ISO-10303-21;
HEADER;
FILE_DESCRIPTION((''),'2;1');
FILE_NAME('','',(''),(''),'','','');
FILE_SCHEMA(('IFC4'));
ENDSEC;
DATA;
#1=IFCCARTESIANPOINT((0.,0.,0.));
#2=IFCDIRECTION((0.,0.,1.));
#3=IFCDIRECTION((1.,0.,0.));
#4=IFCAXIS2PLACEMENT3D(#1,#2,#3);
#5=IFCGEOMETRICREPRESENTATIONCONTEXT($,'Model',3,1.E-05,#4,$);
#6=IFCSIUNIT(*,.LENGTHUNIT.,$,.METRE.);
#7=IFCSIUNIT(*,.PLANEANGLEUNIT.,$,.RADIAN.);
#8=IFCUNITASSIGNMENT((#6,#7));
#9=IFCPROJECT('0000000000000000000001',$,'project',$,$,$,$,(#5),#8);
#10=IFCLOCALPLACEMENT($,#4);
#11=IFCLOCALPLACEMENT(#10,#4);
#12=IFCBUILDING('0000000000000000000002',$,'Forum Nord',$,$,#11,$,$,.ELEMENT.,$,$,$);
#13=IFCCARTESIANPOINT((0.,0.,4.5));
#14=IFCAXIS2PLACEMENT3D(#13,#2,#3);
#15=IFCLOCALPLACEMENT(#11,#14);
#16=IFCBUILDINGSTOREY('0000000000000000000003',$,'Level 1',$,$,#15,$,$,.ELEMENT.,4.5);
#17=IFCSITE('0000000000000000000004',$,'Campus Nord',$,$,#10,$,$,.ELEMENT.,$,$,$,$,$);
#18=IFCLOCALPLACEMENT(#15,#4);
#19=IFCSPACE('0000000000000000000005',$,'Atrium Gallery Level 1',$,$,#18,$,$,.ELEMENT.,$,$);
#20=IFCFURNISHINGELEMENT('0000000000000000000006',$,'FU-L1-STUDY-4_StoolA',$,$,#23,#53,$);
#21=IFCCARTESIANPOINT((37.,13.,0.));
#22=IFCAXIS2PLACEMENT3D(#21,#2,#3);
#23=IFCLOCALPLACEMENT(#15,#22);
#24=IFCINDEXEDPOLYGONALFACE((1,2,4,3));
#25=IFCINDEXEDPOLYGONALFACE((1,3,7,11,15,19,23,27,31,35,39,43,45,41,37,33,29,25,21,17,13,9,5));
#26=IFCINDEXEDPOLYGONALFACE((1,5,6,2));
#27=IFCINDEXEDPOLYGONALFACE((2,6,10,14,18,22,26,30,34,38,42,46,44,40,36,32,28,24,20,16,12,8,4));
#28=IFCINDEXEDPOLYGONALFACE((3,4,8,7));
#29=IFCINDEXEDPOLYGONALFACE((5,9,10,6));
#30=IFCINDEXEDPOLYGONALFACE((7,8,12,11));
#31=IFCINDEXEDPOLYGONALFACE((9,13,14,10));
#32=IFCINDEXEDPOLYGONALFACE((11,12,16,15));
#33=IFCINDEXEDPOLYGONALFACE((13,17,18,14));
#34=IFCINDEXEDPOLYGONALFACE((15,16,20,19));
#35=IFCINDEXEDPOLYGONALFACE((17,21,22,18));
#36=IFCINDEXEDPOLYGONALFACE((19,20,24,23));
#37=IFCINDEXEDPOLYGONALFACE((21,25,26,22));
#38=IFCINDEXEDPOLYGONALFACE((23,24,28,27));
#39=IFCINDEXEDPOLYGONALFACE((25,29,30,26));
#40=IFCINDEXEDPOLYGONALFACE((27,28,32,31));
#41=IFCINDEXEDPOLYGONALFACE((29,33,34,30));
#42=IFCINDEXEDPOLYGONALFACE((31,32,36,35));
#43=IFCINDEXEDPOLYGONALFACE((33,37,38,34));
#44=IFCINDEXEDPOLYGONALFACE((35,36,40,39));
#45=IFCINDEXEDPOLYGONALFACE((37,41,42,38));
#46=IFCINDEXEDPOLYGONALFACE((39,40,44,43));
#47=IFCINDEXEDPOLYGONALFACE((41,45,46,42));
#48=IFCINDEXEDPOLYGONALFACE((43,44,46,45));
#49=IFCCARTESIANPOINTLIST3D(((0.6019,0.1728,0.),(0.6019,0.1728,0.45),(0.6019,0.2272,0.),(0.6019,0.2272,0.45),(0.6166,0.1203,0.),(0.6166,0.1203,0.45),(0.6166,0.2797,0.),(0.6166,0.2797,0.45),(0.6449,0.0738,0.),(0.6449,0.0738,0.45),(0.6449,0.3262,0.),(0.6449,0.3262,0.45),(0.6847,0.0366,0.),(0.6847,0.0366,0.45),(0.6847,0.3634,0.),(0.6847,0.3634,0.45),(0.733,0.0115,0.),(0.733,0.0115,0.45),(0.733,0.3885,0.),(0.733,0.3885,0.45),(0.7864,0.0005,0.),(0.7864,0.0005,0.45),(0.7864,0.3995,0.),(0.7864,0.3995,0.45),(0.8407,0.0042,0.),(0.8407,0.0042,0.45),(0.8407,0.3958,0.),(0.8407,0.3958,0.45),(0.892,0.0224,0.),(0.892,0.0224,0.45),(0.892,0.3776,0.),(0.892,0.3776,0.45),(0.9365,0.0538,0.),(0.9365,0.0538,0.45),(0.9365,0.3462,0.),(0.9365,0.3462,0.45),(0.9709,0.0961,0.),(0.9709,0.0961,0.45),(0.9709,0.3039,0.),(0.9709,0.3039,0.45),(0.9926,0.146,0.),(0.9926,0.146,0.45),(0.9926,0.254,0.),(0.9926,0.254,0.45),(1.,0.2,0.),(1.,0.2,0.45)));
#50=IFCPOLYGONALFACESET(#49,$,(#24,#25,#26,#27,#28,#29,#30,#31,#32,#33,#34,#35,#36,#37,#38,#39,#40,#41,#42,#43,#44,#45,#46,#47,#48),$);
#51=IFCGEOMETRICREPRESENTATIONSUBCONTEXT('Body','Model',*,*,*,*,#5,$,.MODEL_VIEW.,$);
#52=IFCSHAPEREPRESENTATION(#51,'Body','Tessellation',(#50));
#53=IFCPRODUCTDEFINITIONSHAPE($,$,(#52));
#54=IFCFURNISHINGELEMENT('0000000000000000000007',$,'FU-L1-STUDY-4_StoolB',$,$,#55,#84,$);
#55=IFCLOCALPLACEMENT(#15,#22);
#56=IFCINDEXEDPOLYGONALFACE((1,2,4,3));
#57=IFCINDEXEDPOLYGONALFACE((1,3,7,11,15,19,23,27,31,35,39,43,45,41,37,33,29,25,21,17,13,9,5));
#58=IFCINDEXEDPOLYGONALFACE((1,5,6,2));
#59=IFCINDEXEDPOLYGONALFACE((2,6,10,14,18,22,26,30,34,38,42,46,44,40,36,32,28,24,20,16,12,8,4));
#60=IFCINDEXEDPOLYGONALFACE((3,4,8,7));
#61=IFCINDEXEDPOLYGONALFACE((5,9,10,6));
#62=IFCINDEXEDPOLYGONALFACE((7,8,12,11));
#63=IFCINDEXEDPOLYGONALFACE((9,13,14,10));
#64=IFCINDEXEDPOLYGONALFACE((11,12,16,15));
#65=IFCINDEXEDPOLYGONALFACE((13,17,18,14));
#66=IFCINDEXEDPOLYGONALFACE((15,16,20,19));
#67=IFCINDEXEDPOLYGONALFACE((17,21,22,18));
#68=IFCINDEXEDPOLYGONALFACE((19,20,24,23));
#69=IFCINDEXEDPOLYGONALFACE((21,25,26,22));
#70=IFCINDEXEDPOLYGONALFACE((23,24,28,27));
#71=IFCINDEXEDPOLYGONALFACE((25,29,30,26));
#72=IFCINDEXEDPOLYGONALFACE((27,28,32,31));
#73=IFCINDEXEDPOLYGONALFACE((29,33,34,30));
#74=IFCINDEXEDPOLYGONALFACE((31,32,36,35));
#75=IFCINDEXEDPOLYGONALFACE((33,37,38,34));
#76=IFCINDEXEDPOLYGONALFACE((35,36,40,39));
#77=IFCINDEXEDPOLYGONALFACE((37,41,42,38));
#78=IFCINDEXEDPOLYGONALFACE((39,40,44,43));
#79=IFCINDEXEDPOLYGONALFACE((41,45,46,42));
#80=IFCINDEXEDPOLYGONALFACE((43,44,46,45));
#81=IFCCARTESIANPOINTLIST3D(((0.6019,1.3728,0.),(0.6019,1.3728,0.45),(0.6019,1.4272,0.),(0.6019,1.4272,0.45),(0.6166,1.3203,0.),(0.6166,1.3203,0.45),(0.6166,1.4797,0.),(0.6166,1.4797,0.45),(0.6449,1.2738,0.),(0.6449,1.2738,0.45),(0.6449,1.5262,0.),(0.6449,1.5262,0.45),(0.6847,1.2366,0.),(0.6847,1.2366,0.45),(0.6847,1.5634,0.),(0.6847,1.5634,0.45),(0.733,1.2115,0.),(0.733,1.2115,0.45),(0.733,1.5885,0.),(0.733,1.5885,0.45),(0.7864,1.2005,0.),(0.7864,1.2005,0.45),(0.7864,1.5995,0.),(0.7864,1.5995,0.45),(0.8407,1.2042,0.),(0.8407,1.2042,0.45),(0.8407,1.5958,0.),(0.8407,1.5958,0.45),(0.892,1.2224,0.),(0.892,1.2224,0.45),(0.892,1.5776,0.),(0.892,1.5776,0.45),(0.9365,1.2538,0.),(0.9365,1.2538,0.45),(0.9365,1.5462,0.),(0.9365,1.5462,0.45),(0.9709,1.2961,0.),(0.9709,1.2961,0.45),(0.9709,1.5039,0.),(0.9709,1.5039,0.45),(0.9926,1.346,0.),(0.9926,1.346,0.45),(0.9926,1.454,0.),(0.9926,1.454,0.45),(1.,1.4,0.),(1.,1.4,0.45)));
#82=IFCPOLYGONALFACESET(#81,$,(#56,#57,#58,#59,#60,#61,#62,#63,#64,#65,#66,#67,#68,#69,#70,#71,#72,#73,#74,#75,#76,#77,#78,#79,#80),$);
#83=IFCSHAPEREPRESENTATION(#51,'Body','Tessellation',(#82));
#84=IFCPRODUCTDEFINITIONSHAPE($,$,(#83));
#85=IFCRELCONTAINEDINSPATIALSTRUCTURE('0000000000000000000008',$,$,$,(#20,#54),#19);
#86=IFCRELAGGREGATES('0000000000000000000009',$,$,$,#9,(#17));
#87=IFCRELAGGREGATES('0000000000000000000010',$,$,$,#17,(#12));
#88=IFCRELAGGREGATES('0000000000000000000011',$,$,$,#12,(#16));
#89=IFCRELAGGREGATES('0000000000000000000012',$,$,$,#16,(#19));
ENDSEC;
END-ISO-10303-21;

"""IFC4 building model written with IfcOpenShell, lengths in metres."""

from ifc_helpers import new_model, si_unit, frame, frame_2d, origin_with_axes, place, context, subcontext, project, spatial, circle, extrude, element, save


model = new_model("IFC4")

# Units and contexts
model_context = context("Model", 3, precision=1e-05, world=origin_with_axes())
body_context = subcontext(model_context, "Body", "Model", "MODEL_VIEW")
ifc_project = project(units=[si_unit("LENGTHUNIT", "METRE"), si_unit("PLANEANGLEUNIT", "RADIAN")], contexts=[model_context])

# Site, building, storey
site_placement = place(None, origin_with_axes())
site = spatial("IfcSite", under=ifc_project, at=site_placement, Name="Campus Nord", CompositionType="ELEMENT")
building_placement = place(site_placement, origin_with_axes())
building = spatial("IfcBuilding", under=site, at=building_placement, Name="Forum Nord", CompositionType="ELEMENT")
storey_placement = place(building_placement, frame((0.0, 0.0, 4.5), z_axis=(0.0, 0.0, 1.0), x_axis=(1.0, 0.0, 0.0)))
storey = spatial("IfcBuildingStorey", under=building, at=storey_placement, Name="Level 1", CompositionType="ELEMENT", Elevation=4.5)

# Shared definitions
space_placement = place(storey_placement, origin_with_axes())
space = spatial("IfcSpace", under=storey, at=space_placement, Name="Atrium Gallery Level 1", CompositionType="ELEMENT")

# Furnishing elements
furnishing_1_placement = place(storey_placement, frame((37.0, 13.0, 0.0), z_axis=(0.0, 0.0, 1.0), x_axis=(1.0, 0.0, 0.0)))
element("IfcFurnishingElement", 1, at=furnishing_1_placement, inside=space, Name="FU-L1-STUDY-4_StoolA", context=body_context, shape_type="SweptSolid", body=[
    extrude(circle(Radius=0.2, at=frame_2d((0.8, 0.2), x_axis=(1.0, 0.0))), origin_with_axes(), (0.0, 0.0, 1.0), 0.45),
])
furnishing_2_placement = place(storey_placement, frame((37.0, 13.0, 0.0), z_axis=(0.0, 0.0, 1.0), x_axis=(1.0, 0.0, 0.0)))
element("IfcFurnishingElement", 2, at=furnishing_2_placement, inside=space, Name="FU-L1-STUDY-4_StoolB", context=body_context, shape_type="SweptSolid", body=[
    extrude(circle(Radius=0.2, at=frame_2d((0.8, 1.4), x_axis=(1.0, 0.0))), origin_with_axes(), (0.0, 0.0, 1.0), 0.45),
])

save(model, "model.ifc")
